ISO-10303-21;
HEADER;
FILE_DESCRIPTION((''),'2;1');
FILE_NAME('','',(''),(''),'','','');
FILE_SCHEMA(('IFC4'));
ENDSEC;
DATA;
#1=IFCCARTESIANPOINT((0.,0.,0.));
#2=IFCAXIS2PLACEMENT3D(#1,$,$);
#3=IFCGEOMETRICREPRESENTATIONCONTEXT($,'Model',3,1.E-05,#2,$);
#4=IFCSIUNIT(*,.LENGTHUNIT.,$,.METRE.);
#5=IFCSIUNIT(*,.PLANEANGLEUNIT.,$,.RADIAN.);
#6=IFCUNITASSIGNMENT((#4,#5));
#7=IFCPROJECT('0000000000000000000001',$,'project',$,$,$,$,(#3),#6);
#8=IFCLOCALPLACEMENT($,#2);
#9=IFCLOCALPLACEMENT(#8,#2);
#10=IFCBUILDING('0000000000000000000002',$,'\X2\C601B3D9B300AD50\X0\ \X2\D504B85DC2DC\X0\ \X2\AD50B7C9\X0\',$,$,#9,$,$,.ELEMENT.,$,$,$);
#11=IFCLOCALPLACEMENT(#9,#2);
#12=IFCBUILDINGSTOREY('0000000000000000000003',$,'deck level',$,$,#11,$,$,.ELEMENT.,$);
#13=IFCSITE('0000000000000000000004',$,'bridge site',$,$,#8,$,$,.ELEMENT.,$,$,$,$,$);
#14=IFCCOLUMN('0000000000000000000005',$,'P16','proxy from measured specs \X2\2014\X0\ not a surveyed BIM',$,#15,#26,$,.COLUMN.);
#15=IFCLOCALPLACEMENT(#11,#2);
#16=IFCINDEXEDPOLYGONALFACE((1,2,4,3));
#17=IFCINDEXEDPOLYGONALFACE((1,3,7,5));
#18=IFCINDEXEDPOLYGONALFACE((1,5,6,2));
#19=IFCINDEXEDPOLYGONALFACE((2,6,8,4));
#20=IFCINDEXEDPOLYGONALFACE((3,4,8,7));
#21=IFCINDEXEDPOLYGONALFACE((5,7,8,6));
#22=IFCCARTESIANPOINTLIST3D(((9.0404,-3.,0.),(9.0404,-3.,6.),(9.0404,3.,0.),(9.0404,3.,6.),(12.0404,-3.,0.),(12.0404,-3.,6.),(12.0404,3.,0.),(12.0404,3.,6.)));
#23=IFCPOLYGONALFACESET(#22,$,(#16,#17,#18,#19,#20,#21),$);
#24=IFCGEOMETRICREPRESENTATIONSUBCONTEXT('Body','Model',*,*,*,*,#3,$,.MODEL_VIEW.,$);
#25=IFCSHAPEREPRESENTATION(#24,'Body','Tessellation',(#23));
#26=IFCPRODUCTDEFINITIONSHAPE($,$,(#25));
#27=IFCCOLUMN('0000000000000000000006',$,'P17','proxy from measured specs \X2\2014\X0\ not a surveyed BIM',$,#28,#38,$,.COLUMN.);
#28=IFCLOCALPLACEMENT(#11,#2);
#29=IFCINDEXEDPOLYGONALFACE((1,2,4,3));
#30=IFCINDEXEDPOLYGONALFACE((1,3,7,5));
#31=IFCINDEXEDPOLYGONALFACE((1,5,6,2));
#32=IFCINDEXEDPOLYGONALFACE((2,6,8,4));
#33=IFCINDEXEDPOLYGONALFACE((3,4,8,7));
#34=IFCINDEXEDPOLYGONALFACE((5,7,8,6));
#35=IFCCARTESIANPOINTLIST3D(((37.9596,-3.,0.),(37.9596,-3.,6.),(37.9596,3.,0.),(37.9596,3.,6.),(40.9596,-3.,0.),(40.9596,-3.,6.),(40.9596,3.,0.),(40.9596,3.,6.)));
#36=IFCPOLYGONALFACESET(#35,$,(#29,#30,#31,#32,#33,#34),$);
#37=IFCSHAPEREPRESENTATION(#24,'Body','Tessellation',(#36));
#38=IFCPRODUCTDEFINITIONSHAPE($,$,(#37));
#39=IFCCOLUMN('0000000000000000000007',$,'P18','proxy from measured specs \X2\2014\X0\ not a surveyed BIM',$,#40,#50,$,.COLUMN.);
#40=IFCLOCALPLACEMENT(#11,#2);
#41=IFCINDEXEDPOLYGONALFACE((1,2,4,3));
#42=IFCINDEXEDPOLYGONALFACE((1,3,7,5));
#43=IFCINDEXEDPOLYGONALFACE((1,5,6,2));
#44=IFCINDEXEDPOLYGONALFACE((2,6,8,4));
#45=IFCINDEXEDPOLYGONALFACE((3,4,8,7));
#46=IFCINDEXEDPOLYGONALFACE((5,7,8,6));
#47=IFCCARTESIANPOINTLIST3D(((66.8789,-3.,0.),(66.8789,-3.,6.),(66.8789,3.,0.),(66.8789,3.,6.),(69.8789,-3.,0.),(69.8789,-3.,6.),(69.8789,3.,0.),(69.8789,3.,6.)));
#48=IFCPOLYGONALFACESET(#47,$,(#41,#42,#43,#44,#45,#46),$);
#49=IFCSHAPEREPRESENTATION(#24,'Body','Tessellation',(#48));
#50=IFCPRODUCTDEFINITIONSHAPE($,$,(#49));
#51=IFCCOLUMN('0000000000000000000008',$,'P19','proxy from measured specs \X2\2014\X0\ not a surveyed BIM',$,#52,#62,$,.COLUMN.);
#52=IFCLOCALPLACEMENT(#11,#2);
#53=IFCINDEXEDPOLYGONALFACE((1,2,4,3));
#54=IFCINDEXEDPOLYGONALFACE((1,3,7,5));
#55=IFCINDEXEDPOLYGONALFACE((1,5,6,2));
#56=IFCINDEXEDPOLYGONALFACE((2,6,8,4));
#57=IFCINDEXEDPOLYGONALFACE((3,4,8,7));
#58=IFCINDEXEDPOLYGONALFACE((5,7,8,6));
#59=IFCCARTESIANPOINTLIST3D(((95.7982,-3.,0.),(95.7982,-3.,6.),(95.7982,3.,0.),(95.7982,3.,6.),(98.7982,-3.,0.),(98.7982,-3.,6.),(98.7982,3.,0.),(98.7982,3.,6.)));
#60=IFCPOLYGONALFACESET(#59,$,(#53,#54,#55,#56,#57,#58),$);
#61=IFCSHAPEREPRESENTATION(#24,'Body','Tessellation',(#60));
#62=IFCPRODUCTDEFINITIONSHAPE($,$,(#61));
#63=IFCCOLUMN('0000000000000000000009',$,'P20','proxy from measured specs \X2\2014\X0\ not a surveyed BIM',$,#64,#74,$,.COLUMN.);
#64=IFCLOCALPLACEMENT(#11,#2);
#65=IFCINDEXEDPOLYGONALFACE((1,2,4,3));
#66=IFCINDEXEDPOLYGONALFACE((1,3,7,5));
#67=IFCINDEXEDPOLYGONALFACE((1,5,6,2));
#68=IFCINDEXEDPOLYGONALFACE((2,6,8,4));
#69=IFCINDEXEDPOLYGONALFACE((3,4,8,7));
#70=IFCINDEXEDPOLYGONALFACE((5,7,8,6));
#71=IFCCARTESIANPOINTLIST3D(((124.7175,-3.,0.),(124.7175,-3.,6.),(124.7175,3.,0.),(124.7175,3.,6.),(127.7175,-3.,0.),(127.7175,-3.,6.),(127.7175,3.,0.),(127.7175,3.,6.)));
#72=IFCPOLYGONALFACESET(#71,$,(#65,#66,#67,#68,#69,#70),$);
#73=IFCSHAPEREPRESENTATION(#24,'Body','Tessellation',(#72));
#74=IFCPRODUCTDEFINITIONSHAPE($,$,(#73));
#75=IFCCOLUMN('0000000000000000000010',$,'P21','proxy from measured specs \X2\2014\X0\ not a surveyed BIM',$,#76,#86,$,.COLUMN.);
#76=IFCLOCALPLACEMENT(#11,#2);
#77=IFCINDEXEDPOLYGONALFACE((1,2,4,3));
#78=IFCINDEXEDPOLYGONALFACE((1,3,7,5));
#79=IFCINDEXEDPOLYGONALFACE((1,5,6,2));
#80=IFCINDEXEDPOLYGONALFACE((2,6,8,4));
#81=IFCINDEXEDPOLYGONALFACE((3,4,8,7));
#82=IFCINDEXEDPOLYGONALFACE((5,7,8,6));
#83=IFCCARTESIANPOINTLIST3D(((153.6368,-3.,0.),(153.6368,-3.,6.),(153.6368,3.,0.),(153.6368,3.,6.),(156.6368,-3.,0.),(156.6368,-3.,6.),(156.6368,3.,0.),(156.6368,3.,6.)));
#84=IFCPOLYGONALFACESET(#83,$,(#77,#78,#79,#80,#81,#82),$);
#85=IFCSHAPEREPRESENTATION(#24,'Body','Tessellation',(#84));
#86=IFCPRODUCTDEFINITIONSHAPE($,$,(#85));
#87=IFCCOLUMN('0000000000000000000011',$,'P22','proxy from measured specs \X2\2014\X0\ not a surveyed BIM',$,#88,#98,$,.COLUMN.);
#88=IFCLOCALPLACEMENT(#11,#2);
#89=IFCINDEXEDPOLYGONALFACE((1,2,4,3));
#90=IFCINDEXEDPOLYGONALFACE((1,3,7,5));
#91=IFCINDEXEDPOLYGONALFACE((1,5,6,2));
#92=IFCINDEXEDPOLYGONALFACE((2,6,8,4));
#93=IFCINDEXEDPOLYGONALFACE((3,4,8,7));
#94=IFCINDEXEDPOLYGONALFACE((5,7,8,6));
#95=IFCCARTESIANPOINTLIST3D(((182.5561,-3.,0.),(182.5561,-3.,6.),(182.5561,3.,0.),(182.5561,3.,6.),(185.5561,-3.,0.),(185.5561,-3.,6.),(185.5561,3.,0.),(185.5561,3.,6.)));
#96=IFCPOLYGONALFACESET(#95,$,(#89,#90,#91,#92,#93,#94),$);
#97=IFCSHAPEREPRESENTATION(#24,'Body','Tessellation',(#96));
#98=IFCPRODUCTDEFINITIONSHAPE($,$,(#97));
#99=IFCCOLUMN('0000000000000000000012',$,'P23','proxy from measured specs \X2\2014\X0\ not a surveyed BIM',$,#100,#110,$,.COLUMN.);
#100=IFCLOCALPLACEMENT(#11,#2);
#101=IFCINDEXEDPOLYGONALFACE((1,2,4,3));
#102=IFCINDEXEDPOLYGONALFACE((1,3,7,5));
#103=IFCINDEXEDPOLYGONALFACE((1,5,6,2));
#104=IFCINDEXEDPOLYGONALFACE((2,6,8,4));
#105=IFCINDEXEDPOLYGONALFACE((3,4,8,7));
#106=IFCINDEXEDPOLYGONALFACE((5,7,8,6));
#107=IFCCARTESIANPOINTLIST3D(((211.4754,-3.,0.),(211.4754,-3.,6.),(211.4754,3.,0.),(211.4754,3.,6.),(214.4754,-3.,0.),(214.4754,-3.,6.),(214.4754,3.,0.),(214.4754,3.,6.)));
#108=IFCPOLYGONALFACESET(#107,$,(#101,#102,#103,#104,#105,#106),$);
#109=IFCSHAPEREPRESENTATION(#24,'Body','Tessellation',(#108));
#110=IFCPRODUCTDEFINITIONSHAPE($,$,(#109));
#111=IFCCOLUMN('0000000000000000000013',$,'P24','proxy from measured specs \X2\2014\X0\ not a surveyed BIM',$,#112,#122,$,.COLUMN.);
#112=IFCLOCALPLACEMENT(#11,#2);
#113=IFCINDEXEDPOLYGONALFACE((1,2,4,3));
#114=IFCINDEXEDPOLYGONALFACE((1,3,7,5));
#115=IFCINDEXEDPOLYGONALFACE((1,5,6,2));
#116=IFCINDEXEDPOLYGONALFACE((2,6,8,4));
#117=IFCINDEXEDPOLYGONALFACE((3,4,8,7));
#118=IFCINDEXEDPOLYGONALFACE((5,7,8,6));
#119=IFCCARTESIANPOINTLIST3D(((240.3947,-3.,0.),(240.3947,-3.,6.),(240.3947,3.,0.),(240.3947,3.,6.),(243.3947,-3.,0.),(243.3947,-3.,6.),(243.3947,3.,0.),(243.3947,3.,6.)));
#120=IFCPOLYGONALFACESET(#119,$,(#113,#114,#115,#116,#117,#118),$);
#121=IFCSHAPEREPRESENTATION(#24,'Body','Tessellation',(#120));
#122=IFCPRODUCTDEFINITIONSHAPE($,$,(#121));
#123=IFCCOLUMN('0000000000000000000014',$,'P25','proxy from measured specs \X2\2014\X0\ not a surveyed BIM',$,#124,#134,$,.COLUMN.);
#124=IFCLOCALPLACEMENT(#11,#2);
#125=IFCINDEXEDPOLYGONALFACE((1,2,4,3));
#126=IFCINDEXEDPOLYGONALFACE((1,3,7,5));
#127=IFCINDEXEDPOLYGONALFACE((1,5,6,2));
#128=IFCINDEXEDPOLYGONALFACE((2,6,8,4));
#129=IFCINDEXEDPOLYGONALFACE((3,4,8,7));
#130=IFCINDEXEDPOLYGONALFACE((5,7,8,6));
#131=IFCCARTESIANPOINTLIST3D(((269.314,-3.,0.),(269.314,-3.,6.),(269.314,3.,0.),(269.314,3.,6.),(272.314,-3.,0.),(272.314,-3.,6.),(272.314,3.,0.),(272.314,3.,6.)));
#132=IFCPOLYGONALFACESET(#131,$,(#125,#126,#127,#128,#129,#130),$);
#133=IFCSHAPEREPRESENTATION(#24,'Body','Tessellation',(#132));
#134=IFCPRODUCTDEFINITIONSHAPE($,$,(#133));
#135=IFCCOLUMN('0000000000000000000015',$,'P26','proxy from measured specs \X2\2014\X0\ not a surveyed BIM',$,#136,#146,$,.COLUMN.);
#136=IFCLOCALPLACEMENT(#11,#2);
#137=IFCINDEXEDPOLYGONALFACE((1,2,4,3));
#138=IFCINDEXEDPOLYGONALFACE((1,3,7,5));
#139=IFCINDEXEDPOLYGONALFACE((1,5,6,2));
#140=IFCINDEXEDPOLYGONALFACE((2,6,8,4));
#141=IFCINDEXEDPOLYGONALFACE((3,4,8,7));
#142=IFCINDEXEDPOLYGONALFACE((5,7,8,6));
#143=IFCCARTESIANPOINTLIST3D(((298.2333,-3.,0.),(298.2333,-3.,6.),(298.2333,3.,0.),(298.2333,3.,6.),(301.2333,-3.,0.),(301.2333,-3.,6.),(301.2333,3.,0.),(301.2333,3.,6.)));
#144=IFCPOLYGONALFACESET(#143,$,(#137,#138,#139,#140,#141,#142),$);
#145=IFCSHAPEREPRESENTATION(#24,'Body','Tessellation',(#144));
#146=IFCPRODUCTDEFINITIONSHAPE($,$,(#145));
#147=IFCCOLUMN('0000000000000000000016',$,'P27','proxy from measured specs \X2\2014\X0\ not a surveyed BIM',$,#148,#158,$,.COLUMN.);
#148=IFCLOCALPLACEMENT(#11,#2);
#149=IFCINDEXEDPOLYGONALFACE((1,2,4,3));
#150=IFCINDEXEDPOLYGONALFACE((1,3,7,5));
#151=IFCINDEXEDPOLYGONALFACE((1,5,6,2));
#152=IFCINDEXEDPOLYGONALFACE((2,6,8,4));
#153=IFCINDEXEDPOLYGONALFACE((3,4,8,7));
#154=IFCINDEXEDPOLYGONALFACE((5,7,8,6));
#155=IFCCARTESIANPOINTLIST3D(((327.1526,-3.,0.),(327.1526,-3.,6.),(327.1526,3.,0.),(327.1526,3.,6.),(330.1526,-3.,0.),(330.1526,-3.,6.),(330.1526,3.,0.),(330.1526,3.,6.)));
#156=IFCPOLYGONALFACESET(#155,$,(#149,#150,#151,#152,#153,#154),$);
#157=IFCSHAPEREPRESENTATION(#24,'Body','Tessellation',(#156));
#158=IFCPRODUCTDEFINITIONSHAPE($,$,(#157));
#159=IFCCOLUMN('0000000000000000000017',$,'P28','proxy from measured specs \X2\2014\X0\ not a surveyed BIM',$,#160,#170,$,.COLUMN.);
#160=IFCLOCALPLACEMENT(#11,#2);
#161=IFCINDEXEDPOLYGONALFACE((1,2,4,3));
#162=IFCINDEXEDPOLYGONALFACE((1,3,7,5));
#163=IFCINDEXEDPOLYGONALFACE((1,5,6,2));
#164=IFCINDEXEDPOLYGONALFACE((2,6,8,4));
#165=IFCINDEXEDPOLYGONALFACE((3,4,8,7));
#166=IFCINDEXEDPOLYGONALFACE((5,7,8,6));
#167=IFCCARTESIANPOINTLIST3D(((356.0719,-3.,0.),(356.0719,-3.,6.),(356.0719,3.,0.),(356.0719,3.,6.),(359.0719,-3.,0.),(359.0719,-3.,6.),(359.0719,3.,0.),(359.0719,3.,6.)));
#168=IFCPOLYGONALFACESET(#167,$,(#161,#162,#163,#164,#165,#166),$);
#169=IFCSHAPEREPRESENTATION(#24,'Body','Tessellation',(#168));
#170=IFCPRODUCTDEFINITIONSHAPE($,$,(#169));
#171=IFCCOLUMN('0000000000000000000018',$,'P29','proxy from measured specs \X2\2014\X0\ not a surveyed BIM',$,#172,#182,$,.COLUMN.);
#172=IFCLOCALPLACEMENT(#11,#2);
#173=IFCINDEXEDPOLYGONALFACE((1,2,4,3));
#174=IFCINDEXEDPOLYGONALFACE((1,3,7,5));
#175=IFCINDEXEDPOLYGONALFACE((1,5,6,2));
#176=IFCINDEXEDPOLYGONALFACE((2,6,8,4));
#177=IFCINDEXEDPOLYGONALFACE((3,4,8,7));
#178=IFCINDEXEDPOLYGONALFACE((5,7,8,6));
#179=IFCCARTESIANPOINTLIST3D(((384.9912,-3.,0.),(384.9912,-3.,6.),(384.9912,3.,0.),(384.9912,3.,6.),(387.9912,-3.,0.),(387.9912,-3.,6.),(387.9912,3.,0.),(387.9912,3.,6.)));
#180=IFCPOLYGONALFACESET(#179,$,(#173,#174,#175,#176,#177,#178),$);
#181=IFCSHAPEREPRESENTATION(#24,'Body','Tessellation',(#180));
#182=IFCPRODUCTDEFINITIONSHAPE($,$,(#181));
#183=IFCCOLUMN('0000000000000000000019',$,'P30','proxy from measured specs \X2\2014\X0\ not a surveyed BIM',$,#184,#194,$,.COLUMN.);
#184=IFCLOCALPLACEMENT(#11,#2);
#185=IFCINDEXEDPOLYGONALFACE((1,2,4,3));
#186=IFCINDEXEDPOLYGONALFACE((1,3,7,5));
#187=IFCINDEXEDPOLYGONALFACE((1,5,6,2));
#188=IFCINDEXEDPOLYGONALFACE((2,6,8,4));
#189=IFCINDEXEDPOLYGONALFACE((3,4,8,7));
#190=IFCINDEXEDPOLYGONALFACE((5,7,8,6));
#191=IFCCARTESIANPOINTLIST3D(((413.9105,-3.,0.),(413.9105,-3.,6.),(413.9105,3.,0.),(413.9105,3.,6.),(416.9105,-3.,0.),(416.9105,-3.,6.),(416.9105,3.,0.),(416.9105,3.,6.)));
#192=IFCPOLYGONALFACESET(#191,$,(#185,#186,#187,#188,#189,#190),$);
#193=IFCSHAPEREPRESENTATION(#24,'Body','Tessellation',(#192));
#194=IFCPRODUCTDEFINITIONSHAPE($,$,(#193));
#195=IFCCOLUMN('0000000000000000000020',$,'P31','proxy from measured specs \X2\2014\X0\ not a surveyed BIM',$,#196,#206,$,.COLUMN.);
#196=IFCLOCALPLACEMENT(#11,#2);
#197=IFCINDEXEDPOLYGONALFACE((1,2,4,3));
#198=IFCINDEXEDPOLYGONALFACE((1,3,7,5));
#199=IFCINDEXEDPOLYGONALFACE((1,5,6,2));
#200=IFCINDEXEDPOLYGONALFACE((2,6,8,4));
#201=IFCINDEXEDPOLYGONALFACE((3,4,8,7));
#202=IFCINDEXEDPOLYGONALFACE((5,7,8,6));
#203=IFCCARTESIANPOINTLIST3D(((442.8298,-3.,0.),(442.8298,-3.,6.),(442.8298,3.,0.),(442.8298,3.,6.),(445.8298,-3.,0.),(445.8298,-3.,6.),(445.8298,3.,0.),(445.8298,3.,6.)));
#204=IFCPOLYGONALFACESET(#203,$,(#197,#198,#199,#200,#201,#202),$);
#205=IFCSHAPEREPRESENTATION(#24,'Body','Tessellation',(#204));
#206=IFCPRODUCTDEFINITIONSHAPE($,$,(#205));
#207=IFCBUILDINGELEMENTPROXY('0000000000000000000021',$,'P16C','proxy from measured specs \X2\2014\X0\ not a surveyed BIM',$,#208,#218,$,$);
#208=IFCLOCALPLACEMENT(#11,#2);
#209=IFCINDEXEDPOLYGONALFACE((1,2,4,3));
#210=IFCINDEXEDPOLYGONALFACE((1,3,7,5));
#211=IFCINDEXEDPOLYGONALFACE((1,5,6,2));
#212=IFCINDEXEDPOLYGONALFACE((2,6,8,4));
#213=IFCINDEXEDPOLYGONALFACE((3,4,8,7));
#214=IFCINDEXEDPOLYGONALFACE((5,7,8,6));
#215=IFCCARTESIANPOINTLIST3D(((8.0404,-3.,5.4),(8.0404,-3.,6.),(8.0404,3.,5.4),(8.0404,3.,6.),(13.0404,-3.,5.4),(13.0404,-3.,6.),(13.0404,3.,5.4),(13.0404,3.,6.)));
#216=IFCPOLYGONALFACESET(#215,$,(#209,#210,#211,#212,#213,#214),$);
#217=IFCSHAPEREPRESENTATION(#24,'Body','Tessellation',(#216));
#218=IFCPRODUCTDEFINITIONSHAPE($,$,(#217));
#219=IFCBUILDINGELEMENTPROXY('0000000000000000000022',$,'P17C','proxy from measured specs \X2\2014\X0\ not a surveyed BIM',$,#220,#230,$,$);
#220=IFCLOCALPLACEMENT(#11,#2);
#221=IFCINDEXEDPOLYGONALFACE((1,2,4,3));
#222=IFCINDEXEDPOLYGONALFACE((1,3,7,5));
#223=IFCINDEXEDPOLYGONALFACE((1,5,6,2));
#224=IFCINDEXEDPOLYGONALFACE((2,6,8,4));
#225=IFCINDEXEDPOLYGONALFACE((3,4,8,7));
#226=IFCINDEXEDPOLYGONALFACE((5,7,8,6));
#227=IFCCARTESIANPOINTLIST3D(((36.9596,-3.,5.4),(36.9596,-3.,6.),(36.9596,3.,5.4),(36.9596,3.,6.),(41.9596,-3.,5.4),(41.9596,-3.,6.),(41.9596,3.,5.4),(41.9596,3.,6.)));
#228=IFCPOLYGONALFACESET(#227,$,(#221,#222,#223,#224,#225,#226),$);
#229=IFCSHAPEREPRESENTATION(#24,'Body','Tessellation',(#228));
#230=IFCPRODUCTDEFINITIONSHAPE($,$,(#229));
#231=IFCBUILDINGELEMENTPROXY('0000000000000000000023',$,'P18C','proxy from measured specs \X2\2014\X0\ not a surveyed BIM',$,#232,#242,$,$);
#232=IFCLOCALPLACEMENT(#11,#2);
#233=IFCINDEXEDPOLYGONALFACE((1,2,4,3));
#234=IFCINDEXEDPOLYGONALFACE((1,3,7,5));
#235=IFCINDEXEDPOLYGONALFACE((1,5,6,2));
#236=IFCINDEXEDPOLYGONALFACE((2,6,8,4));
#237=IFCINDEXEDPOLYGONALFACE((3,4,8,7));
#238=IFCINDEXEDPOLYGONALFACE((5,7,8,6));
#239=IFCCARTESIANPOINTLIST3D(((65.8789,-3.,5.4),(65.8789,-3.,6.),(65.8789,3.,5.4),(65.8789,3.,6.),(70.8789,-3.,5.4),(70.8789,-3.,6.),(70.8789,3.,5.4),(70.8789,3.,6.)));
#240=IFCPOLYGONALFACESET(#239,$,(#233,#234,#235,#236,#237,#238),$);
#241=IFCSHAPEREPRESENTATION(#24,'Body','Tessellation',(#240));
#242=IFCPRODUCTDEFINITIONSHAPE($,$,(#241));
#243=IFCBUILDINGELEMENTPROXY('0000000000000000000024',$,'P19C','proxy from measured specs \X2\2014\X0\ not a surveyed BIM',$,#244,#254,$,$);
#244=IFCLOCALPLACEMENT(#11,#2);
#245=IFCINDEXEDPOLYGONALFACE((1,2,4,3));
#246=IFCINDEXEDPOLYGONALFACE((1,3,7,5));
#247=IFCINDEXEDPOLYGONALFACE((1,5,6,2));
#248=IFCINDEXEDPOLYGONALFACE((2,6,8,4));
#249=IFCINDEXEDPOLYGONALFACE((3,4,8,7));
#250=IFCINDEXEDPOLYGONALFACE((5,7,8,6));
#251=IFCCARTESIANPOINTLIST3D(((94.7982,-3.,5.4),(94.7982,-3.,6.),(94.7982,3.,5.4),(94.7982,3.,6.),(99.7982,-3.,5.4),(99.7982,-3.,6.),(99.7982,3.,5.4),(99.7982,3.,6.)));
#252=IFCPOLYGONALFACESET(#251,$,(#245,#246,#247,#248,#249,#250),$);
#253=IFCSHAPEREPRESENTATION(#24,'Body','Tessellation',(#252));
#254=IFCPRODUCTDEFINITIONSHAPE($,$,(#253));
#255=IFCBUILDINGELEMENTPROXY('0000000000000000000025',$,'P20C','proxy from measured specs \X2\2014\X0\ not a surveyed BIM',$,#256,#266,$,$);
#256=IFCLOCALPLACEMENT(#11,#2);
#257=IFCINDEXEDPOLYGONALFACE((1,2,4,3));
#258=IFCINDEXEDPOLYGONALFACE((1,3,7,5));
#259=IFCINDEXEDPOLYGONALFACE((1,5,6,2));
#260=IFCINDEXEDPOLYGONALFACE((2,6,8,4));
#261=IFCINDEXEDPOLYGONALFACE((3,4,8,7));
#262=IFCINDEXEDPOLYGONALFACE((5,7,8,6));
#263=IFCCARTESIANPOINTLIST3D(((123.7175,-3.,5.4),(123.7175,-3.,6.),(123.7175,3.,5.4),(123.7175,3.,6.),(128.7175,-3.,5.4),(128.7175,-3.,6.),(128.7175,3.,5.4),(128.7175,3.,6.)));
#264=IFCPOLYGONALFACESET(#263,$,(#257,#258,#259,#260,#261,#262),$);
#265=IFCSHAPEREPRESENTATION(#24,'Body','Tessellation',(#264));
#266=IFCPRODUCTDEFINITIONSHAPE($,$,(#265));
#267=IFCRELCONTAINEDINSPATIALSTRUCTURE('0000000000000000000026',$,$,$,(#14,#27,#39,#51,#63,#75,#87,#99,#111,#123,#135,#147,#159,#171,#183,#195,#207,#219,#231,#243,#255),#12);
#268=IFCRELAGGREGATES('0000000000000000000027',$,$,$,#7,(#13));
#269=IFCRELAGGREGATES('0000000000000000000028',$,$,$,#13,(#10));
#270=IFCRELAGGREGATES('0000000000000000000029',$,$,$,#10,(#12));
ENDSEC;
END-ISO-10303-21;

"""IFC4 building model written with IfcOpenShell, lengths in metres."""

from ifc_helpers import new_model, si_unit, frame, origin, origin_2d, place, context, subcontext, project, spatial, rectangle, extrude, element, save


model = new_model("IFC4")

# Units and contexts
model_context = context("Model", 3, precision=1e-05, world=origin())
body_context = subcontext(model_context, "Body", "Model", "MODEL_VIEW")
ifc_project = project(units=[si_unit("LENGTHUNIT", "METRE"), si_unit("PLANEANGLEUNIT", "RADIAN")], contexts=[model_context])

# Site, building, storey
site_placement = place(None, origin())
site = spatial("IfcSite", under=ifc_project, at=site_placement, Name="bridge site", CompositionType="ELEMENT")
building_placement = place(site_placement, origin())
building = spatial("IfcBuilding", under=site, at=building_placement, Name="영동대교 프록시 교량", CompositionType="ELEMENT")
storey_placement = place(building_placement, origin())
storey = spatial("IfcBuildingStorey", under=building, at=storey_placement, Name="deck level", CompositionType="ELEMENT")

# Columns
for number, where, name in (
    (1, (10.5404, 0.0, 0.0), "P16"),
    (2, (39.4596, 0.0, 0.0), "P17"),
    (3, (68.3789, 0.0, 0.0), "P18"),
    (4, (97.2982, 0.0, 0.0), "P19"),
    (5, (126.2175, 0.0, 0.0), "P20"),
    (6, (155.1368, 0.0, 0.0), "P21"),
    (7, (184.0561, 0.0, 0.0), "P22"),
    (8, (212.9754, 0.0, 0.0), "P23"),
    (9, (241.8947, 0.0, 0.0), "P24"),
    (10, (270.814, 0.0, 0.0), "P25"),
    (11, (299.7333, 0.0, 0.0), "P26"),
    (12, (328.6526, 0.0, 0.0), "P27"),
    (13, (357.5719, 0.0, 0.0), "P28"),
    (14, (386.4912, 0.0, 0.0), "P29"),
    (15, (415.4105, 0.0, 0.0), "P30"),
    (16, (444.3298, 0.0, 0.0), "P31"),
):
    element("IfcColumn", number, at=place(storey_placement, frame(where)), inside=storey, Name=name, Description="proxy from measured specs — not a surveyed BIM", PredefinedType="COLUMN", context=body_context, shape_type="SweptSolid", body=[
        extrude(rectangle(XDim=3.0, YDim=6.0, at=origin_2d()), origin(), (0.0, 0.0, 1.0), 6.0),
    ])

# Building element proxies
for number, where, name in (
    (17, (10.5404, 0.0, 5.4), "P16C"),
    (18, (39.4596, 0.0, 5.4), "P17C"),
    (19, (68.3789, 0.0, 5.4), "P18C"),
    (20, (97.2982, 0.0, 5.4), "P19C"),
    (21, (126.2175, 0.0, 5.4), "P20C"),
):
    element("IfcBuildingElementProxy", number, at=place(storey_placement, frame(where)), inside=storey, Name=name, Description="proxy from measured specs — not a surveyed BIM", context=body_context, shape_type="SweptSolid", body=[
        extrude(rectangle(XDim=5.0, YDim=6.0, at=origin_2d()), origin(), (0.0, 0.0, 1.0), 0.6),
    ])

save(model, "model.ifc")
